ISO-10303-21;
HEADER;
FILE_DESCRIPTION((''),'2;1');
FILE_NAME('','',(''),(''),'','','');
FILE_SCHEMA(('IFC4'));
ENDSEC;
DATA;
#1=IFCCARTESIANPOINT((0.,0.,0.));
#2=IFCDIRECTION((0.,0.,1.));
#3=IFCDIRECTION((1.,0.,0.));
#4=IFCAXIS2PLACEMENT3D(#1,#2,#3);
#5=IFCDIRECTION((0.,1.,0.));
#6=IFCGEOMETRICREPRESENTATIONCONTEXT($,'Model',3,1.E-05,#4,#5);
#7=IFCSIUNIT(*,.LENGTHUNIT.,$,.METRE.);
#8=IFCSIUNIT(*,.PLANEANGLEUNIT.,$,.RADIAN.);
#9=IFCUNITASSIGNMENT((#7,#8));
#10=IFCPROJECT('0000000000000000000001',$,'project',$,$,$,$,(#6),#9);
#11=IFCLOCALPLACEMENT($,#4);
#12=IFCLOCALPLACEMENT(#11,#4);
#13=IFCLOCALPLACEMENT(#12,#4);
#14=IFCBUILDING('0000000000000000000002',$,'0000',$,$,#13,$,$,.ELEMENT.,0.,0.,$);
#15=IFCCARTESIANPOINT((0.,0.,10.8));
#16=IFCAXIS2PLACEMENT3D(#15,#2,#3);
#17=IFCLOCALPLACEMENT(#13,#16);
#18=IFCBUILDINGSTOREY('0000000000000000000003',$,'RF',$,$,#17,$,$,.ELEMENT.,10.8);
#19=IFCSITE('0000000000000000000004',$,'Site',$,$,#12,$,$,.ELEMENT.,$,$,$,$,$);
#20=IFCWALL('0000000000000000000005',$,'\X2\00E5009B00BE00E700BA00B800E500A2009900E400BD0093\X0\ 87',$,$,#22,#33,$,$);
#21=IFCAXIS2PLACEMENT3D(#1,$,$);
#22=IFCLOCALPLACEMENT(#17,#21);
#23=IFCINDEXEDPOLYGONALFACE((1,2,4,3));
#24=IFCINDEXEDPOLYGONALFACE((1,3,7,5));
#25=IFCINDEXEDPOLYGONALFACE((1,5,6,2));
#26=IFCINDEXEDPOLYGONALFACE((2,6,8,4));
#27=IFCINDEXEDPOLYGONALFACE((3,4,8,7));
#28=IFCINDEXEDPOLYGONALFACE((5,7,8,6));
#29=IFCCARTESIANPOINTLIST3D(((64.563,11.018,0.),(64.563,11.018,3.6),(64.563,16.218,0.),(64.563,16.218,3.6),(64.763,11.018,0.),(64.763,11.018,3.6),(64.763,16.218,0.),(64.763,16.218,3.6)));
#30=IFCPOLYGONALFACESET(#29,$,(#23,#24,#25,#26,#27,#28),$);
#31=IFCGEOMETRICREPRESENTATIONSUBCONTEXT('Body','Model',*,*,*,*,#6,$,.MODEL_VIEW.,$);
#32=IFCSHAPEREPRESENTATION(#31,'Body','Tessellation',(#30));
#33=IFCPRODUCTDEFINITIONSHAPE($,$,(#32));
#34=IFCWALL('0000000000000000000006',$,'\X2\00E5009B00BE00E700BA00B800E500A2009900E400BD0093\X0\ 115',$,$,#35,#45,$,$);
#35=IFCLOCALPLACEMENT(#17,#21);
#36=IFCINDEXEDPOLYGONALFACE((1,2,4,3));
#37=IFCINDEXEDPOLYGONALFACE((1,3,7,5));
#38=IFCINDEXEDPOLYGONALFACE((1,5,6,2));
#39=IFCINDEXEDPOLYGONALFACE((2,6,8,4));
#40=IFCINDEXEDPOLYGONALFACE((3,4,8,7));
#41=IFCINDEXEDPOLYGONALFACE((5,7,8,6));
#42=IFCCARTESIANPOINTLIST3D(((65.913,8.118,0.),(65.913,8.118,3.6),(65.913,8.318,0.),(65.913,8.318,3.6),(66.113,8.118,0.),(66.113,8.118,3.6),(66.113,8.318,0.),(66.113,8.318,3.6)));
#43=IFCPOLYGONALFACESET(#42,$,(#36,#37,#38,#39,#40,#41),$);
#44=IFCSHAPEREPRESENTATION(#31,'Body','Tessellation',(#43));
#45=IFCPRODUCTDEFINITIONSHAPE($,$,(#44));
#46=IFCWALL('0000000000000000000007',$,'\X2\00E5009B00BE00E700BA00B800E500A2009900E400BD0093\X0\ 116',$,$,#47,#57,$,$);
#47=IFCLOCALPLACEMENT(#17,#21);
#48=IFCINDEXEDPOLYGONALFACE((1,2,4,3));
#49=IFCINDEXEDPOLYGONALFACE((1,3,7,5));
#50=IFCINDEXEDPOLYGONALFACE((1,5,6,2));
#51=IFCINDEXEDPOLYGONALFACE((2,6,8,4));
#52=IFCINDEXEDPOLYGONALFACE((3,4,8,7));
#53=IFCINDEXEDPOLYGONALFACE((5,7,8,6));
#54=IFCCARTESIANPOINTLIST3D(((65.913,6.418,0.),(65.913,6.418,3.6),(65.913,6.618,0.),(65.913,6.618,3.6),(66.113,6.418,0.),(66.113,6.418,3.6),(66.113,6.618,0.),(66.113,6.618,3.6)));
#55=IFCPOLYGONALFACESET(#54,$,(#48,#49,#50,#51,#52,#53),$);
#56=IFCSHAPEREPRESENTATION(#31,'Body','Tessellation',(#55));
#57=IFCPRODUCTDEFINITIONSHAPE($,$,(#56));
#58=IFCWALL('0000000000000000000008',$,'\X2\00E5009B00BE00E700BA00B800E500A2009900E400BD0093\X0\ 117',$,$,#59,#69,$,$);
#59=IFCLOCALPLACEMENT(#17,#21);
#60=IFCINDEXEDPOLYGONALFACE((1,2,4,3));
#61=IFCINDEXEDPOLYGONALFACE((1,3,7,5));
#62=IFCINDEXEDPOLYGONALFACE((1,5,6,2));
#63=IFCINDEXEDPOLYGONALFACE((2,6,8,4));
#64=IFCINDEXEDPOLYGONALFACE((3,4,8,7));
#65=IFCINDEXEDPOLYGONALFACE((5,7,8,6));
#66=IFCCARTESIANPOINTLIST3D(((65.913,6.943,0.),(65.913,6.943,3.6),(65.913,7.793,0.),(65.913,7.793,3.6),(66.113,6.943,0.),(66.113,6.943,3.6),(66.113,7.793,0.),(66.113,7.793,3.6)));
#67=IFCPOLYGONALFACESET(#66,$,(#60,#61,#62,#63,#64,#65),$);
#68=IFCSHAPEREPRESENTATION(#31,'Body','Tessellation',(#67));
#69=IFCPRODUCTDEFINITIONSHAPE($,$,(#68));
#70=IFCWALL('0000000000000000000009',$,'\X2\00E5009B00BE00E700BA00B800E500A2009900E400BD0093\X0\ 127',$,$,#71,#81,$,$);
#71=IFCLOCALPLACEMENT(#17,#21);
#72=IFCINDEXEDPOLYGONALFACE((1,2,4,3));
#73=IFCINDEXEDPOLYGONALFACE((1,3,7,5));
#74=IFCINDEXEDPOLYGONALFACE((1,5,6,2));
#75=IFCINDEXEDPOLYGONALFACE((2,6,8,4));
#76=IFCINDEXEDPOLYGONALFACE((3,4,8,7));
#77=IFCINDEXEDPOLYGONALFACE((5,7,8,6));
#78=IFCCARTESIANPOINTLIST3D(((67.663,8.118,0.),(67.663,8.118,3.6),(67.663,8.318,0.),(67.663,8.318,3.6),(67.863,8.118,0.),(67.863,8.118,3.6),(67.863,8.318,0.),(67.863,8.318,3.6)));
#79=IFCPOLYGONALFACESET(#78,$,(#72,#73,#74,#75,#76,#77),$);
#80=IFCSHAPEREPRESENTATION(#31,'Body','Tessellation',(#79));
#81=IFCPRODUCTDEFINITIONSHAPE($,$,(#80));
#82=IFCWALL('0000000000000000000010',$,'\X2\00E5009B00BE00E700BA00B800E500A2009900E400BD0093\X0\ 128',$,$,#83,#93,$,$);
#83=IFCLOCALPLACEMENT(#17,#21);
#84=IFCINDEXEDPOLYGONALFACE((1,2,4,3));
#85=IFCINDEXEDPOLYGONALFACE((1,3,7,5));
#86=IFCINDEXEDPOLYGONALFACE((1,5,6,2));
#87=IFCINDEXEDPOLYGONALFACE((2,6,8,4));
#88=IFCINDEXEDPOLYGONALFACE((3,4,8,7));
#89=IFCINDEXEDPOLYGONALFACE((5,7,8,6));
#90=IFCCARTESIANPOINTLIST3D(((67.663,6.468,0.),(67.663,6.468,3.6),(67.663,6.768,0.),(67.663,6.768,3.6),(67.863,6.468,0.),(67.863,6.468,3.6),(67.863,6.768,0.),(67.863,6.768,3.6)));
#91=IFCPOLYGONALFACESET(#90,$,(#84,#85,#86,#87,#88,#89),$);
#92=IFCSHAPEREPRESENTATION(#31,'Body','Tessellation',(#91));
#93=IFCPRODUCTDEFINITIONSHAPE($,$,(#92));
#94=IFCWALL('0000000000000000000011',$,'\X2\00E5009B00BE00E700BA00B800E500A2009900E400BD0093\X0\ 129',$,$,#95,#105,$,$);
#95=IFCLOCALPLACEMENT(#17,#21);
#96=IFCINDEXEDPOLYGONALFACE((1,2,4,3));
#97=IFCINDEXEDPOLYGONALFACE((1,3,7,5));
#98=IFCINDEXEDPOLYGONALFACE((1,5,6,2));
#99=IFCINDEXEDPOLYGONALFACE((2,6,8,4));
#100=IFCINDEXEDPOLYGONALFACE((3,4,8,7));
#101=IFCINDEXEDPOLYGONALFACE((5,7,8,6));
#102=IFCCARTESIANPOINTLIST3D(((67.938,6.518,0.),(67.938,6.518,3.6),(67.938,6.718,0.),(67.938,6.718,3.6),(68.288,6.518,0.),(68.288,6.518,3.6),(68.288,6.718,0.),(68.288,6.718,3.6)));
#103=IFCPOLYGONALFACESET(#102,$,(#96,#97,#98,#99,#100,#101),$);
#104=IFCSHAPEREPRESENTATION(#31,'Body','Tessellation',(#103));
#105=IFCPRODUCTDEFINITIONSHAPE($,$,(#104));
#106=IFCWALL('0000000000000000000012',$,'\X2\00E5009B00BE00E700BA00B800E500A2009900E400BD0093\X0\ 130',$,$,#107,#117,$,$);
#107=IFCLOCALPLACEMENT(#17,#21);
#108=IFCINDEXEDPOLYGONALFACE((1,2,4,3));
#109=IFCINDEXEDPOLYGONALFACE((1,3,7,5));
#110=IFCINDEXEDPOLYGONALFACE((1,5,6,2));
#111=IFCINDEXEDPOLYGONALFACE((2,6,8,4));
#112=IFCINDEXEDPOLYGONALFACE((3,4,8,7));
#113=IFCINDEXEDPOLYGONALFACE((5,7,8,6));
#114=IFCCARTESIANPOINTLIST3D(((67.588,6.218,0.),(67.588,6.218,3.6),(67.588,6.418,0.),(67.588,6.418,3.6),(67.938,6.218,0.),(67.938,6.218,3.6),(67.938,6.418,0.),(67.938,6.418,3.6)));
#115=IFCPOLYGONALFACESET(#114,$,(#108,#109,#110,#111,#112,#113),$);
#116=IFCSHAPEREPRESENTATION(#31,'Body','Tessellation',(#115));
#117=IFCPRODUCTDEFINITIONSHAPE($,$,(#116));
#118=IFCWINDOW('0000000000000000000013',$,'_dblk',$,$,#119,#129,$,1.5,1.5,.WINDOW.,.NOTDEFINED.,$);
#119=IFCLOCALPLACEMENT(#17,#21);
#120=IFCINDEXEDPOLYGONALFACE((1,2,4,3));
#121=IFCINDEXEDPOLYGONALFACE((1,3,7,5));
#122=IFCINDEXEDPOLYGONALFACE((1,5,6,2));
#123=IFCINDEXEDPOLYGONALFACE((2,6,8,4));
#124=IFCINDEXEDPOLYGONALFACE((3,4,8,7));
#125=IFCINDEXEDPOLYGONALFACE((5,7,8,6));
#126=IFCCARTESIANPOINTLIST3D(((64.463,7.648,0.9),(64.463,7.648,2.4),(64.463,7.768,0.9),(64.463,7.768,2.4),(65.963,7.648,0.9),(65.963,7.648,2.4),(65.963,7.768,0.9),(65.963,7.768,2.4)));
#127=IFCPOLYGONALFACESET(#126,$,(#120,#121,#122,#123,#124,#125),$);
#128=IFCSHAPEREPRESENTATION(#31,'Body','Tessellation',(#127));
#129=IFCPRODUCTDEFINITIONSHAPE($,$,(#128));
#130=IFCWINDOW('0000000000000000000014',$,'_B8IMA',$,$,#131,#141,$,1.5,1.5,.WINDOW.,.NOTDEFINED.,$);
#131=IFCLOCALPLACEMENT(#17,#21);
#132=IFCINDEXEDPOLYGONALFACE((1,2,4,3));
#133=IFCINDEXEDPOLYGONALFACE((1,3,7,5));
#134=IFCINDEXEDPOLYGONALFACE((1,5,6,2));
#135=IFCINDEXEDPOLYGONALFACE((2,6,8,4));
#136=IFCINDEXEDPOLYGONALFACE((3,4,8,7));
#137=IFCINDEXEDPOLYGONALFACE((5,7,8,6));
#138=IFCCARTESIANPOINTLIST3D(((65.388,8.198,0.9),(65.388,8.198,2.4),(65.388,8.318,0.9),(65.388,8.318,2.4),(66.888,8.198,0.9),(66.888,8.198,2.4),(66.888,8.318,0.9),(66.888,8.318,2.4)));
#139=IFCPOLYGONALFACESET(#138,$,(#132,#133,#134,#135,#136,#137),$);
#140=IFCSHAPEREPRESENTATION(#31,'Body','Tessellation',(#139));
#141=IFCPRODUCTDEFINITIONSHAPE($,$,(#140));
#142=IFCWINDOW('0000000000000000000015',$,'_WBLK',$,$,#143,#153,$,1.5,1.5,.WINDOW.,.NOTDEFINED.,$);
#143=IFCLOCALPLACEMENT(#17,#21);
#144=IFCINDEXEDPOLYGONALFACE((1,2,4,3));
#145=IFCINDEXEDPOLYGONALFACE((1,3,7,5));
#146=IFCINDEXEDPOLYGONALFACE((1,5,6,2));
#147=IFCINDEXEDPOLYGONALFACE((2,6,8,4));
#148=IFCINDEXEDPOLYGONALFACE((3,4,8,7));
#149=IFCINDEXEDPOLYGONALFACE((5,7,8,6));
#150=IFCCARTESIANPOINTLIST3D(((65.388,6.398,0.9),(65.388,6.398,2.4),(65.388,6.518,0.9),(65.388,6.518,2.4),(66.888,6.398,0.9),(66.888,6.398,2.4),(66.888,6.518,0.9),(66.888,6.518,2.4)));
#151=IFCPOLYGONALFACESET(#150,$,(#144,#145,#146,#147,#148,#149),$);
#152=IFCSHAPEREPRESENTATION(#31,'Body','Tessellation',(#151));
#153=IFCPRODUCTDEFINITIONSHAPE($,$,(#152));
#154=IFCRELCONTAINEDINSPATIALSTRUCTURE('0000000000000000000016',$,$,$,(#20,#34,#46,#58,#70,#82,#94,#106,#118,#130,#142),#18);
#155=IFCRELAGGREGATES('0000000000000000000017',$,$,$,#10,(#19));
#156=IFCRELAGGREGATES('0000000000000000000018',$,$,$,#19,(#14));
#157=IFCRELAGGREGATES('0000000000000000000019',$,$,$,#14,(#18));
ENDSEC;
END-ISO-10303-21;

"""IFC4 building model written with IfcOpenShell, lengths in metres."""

from ifc_helpers import new_model, si_unit, direction, frame, frame_2d, origin_with_axes, place, context, subcontext, project, spatial, rectangle, extrude, element, save


model = new_model("IFC4")

# Units and contexts
model_context = context("Model", 3, precision=1e-05, world=origin_with_axes(), true_north=direction((0.0, 1.0, 0.0)))
body_context = subcontext(model_context, "Body", "Model", "MODEL_VIEW")
ifc_project = project(units=[si_unit("LENGTHUNIT", "METRE"), si_unit("PLANEANGLEUNIT", "RADIAN")], contexts=[model_context])

# Site, building, storey
placement = place(None, origin_with_axes())
site_placement = place(placement, origin_with_axes())
site = spatial("IfcSite", under=ifc_project, at=site_placement, Name="Site", CompositionType="ELEMENT")
building_placement = place(site_placement, origin_with_axes())
building = spatial("IfcBuilding", under=site, at=building_placement, Name="0000", CompositionType="ELEMENT", ElevationOfRefHeight=0.0, ElevationOfTerrain=0.0)
storey_placement = place(building_placement, frame((0.0, 0.0, 10.8), z_axis=(0.0, 0.0, 1.0), x_axis=(1.0, 0.0, 0.0)))
storey = spatial("IfcBuildingStorey", under=building, at=storey_placement, Name="RF", CompositionType="ELEMENT", Elevation=10.8)

# Walls
for number, where, z_axis, x_axis, name in (
    (1, (64.663, 13.618, 0.0), (0.0, 0.0, 1.0), (0.0, -1.0, 0.0), "å\u009b¾çº¸å¢\u0099ä½\u0093 87"),
):
    element("IfcWall", number, at=place(storey_placement, frame(where, z_axis=z_axis, x_axis=x_axis)), inside=storey, Name=name, context=body_context, shape_type="SweptSolid", body=[
        extrude(rectangle(XDim=5.2, YDim=0.2, at=frame_2d((0.0, 0.0), x_axis=(1.0, 0.0, 0.0))), frame((0.0, 0.0, 0.0), z_axis=(0.0, 0.0, 1.0)), (0.0, 0.0, 1.0), 3.6),
    ])
for number, where, z_axis, x_axis, name in (
    (2, (66.013, 8.218, 0.0), (0.0, 0.0, 1.0), (0.0, 1.0, 0.0), "å\u009b¾çº¸å¢\u0099ä½\u0093 115"),
    (3, (66.013, 6.518, 0.0), (0.0, 0.0, 1.0), (0.0, -1.0, 0.0), "å\u009b¾çº¸å¢\u0099ä½\u0093 116"),
):
    element("IfcWall", number, at=place(storey_placement, frame(where, z_axis=z_axis, x_axis=x_axis)), inside=storey, Name=name, context=body_context, shape_type="SweptSolid", body=[
        extrude(rectangle(XDim=0.2, YDim=0.2, at=frame_2d((0.0, 0.0), x_axis=(1.0, 0.0, 0.0))), frame((0.0, 0.0, 0.0), z_axis=(0.0, 0.0, 1.0)), (0.0, 0.0, 1.0), 3.6),
    ])
wall_1_placement = place(storey_placement, frame((66.013, 7.368, 0.0), z_axis=(0.0, 0.0, 1.0), x_axis=(0.0, -1.0, 0.0)))
element("IfcWall", 4, at=wall_1_placement, inside=storey, Name="å\u009b¾çº¸å¢\u0099ä½\u0093 117", context=body_context, shape_type="SweptSolid", body=[
    extrude(rectangle(XDim=0.85, YDim=0.2, at=frame_2d((0.0, 0.0), x_axis=(1.0, 0.0, 0.0))), frame((0.0, 0.0, 0.0), z_axis=(0.0, 0.0, 1.0)), (0.0, 0.0, 1.0), 3.6),
])
for number, where, z_axis, x_axis, name in (
    (5, (67.763, 8.218, 0.0), (0.0, 0.0, 1.0), (0.0, 1.0, 0.0), "å\u009b¾çº¸å¢\u0099ä½\u0093 127"),
):
    element("IfcWall", number, at=place(storey_placement, frame(where, z_axis=z_axis, x_axis=x_axis)), inside=storey, Name=name, context=body_context, shape_type="SweptSolid", body=[
        extrude(rectangle(XDim=0.2, YDim=0.2, at=frame_2d((0.0, 0.0), x_axis=(1.0, 0.0, 0.0))), frame((0.0, 0.0, 0.0), z_axis=(0.0, 0.0, 1.0)), (0.0, 0.0, 1.0), 3.6),
    ])
wall_2_placement = place(storey_placement, frame((67.763, 6.618, 0.0), z_axis=(0.0, 0.0, 1.0), x_axis=(0.0, -1.0, 0.0)))
element("IfcWall", 6, at=wall_2_placement, inside=storey, Name="å\u009b¾çº¸å¢\u0099ä½\u0093 128", context=body_context, shape_type="SweptSolid", body=[
    extrude(rectangle(XDim=0.3, YDim=0.2, at=frame_2d((0.0, 0.0), x_axis=(1.0, 0.0, 0.0))), frame((0.0, 0.0, 0.0), z_axis=(0.0, 0.0, 1.0)), (0.0, 0.0, 1.0), 3.6),
])
for number, where, z_axis, x_axis, name in (
    (7, (68.113, 6.618, 0.0), (0.0, 0.0, 1.0), (-1.0, 0.0, 0.0), "å\u009b¾çº¸å¢\u0099ä½\u0093 129"),
    (8, (67.763, 6.318, 0.0), (0.0, 0.0, 1.0), (1.0, 0.0, 0.0), "å\u009b¾çº¸å¢\u0099ä½\u0093 130"),
):
    element("IfcWall", number, at=place(storey_placement, frame(where, z_axis=z_axis, x_axis=x_axis)), inside=storey, Name=name, context=body_context, shape_type="SweptSolid", body=[
        extrude(rectangle(XDim=0.35, YDim=0.2, at=frame_2d((0.0, 0.0), x_axis=(1.0, 0.0, 0.0))), frame((0.0, 0.0, 0.0), z_axis=(0.0, 0.0, 1.0)), (0.0, 0.0, 1.0), 3.6),
    ])

# Windows
for number, where, z_axis, x_axis, name in (
    (9, (65.213, 7.708, 0.9), (0.0, 0.0, 1.0), (1.0, 0.0, 0.0), "_dblk"),
    (10, (66.138, 8.258, 0.9), (0.0, 0.0, 1.0), (1.0, 0.0, 0.0), "_B8IMA"),
    (11, (66.138, 6.458, 0.9), (0.0, 0.0, 1.0), (1.0, 0.0, 0.0), "_WBLK"),
):
    element("IfcWindow", number, at=place(storey_placement, frame(where, z_axis=z_axis, x_axis=x_axis)), inside=storey, Name=name, OverallHeight=1.5, OverallWidth=1.5, PartitioningType="NOTDEFINED", PredefinedType="WINDOW", context=body_context, shape_type="SweptSolid", body=[
        extrude(rectangle(XDim=1.5, YDim=0.12, at=frame_2d((0.0, 0.0), x_axis=(1.0, 0.0, 0.0))), frame((0.0, 0.0, 0.0), z_axis=(0.0, 0.0, 1.0)), (0.0, 0.0, 1.0), 1.5),
    ])

save(model, "model.ifc")
